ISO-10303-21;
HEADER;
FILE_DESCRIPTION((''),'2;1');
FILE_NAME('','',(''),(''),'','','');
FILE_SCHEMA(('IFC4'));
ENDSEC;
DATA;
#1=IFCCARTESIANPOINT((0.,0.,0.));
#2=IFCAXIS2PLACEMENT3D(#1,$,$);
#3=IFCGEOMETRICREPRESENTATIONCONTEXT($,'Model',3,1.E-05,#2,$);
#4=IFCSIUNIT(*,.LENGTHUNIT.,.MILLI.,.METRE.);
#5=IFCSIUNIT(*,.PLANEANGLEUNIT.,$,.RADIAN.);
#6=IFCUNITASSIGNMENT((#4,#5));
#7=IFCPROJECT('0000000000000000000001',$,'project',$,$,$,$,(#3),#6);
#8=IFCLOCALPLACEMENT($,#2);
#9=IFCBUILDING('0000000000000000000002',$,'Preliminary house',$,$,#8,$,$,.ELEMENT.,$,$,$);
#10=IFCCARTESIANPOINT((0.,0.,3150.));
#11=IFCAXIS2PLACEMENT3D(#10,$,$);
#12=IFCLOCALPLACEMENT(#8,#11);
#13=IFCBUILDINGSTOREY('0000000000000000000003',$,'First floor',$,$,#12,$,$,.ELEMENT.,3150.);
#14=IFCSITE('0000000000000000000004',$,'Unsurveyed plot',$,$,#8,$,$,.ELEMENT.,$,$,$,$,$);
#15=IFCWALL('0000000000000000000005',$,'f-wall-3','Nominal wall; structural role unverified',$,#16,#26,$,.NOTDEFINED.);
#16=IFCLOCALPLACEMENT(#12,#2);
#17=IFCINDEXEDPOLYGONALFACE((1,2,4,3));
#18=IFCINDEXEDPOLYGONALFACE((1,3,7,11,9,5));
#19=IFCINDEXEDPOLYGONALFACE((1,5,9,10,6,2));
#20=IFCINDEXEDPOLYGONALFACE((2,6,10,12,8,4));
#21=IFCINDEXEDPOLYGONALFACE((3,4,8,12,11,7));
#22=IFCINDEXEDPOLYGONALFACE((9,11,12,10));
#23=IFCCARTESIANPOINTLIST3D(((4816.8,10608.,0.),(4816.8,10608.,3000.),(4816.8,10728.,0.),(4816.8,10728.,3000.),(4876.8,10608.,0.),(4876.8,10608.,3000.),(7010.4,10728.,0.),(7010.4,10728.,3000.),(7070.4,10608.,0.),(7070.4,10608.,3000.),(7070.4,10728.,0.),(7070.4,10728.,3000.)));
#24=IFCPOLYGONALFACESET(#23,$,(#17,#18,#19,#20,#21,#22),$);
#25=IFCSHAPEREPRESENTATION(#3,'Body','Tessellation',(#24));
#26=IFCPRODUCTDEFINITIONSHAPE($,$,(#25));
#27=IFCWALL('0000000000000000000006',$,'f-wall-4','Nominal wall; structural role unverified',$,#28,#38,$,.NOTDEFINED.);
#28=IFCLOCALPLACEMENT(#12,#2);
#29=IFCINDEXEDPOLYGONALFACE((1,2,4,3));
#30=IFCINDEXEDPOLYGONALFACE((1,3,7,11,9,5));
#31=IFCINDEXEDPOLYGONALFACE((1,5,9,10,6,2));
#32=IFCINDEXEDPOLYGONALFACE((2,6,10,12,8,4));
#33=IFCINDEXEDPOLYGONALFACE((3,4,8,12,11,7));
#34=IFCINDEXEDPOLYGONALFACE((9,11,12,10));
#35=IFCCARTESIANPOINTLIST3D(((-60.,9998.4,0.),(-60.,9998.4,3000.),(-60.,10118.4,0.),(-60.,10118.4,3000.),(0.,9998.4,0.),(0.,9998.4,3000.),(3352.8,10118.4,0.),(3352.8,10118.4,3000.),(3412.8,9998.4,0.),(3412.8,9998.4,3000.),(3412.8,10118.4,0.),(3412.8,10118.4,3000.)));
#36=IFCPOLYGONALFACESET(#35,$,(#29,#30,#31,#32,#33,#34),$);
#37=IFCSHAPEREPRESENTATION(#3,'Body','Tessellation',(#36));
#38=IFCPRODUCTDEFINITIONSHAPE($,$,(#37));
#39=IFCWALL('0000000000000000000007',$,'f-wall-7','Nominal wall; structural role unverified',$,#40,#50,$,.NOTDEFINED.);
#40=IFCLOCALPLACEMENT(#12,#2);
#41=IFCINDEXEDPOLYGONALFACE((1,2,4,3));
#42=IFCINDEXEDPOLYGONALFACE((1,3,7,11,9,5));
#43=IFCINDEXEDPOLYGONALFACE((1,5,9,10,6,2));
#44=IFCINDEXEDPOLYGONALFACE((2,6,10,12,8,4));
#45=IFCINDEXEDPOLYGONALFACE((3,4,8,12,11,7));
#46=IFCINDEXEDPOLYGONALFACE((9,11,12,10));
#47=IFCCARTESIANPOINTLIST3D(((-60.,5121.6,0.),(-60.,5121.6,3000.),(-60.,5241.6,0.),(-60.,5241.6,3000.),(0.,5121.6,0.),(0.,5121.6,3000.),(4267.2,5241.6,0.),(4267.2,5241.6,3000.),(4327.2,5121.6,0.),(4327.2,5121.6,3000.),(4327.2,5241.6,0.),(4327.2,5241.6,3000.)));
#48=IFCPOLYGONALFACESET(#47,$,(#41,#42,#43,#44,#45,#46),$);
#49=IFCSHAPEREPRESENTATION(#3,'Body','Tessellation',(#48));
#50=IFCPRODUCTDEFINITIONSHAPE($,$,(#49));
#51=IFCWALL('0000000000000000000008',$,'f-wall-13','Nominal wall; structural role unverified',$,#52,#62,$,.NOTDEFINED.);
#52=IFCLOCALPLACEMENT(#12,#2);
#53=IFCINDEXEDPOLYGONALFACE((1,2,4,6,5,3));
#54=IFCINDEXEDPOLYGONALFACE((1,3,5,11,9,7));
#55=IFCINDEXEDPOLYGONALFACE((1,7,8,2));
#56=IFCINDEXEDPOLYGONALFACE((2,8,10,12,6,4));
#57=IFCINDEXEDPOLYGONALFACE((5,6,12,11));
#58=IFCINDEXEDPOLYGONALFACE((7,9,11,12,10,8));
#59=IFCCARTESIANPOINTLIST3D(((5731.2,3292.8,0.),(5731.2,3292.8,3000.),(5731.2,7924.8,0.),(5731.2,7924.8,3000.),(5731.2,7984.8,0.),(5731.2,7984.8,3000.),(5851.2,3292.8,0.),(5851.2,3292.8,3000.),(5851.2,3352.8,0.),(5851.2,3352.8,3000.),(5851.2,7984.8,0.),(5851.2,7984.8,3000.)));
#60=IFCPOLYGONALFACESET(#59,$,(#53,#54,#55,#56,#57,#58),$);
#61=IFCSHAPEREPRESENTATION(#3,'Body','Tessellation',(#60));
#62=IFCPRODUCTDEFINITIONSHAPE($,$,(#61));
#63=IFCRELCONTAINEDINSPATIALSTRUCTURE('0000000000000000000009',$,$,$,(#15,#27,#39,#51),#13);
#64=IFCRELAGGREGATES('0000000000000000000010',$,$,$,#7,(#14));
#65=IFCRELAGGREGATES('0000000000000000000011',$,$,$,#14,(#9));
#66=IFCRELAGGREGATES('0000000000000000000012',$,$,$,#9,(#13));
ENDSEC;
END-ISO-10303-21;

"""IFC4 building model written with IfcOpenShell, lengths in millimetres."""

from ifc_helpers import new_model, si_unit, frame, origin, place, context, project, spatial, polyline, outline, extrude, element, save


model = new_model("IFC4")

# Units and contexts
model_context = context("Model", 3, precision=1e-05, world=origin())
ifc_project = project(units=[si_unit("LENGTHUNIT", "METRE", prefix="MILLI"), si_unit("PLANEANGLEUNIT", "RADIAN")], contexts=[model_context])

# Site, building, storey
placement_1 = place(None, origin())
site = spatial("IfcSite", under=ifc_project, at=placement_1, Name="Unsurveyed plot", CompositionType="ELEMENT")
building = spatial("IfcBuilding", under=site, at=placement_1, Name="Preliminary house", CompositionType="ELEMENT")
placement_2 = place(placement_1, frame((0.0, 0.0, 3150.0)))
storey = spatial("IfcBuildingStorey", under=building, at=placement_2, Name="First floor", CompositionType="ELEMENT", Elevation=3150.0)

# Walls
element("IfcWall", 1, at=placement_2, inside=storey, Name="f-wall-3", Description="Nominal wall; structural role unverified", PredefinedType="NOTDEFINED", context=model_context, shape_type="SweptSolid", body=[
    extrude(outline(polyline([(7010.4, 10728.0), (7070.4, 10728.0), (7070.4, 10608.0), (4876.8, 10608.0), (4816.8, 10608.0), (4816.8, 10728.0), (7010.4, 10728.0)])), origin(), (0.0, 0.0, 1.0), 3000.0),
])
element("IfcWall", 2, at=placement_2, inside=storey, Name="f-wall-4", Description="Nominal wall; structural role unverified", PredefinedType="NOTDEFINED", context=model_context, shape_type="SweptSolid", body=[
    extrude(outline(polyline([(3352.8, 10118.4), (3412.8, 10118.4), (3412.8, 9998.4), (0.0, 9998.4), (-60.0, 9998.4), (-60.0, 10118.4), (3352.8, 10118.4)])), origin(), (0.0, 0.0, 1.0), 3000.0),
])

# Wall
element("IfcWall", 3, at=placement_2, inside=storey, Name="f-wall-7", Description="Nominal wall; structural role unverified", PredefinedType="NOTDEFINED", context=model_context, shape_type="SweptSolid", body=[
    extrude(outline(polyline([(4267.2, 5241.6), (4327.2, 5241.6), (4327.2, 5121.6), (0.0, 5121.6), (-60.0, 5121.6), (-60.0, 5241.6), (4267.2, 5241.6)])), origin(), (0.0, 0.0, 1.0), 3000.0),
])

# Wall
element("IfcWall", 4, at=placement_2, inside=storey, Name="f-wall-13", Description="Nominal wall; structural role unverified", PredefinedType="NOTDEFINED", context=model_context, shape_type="SweptSolid", body=[
    extrude(outline(polyline([(5731.2, 7924.8), (5731.2, 7984.8), (5851.2, 7984.8), (5851.2, 3352.8), (5851.2, 3292.8), (5731.2, 3292.8), (5731.2, 7924.8)])), origin(), (0.0, 0.0, 1.0), 3000.0),
])

save(model, "model.ifc")
